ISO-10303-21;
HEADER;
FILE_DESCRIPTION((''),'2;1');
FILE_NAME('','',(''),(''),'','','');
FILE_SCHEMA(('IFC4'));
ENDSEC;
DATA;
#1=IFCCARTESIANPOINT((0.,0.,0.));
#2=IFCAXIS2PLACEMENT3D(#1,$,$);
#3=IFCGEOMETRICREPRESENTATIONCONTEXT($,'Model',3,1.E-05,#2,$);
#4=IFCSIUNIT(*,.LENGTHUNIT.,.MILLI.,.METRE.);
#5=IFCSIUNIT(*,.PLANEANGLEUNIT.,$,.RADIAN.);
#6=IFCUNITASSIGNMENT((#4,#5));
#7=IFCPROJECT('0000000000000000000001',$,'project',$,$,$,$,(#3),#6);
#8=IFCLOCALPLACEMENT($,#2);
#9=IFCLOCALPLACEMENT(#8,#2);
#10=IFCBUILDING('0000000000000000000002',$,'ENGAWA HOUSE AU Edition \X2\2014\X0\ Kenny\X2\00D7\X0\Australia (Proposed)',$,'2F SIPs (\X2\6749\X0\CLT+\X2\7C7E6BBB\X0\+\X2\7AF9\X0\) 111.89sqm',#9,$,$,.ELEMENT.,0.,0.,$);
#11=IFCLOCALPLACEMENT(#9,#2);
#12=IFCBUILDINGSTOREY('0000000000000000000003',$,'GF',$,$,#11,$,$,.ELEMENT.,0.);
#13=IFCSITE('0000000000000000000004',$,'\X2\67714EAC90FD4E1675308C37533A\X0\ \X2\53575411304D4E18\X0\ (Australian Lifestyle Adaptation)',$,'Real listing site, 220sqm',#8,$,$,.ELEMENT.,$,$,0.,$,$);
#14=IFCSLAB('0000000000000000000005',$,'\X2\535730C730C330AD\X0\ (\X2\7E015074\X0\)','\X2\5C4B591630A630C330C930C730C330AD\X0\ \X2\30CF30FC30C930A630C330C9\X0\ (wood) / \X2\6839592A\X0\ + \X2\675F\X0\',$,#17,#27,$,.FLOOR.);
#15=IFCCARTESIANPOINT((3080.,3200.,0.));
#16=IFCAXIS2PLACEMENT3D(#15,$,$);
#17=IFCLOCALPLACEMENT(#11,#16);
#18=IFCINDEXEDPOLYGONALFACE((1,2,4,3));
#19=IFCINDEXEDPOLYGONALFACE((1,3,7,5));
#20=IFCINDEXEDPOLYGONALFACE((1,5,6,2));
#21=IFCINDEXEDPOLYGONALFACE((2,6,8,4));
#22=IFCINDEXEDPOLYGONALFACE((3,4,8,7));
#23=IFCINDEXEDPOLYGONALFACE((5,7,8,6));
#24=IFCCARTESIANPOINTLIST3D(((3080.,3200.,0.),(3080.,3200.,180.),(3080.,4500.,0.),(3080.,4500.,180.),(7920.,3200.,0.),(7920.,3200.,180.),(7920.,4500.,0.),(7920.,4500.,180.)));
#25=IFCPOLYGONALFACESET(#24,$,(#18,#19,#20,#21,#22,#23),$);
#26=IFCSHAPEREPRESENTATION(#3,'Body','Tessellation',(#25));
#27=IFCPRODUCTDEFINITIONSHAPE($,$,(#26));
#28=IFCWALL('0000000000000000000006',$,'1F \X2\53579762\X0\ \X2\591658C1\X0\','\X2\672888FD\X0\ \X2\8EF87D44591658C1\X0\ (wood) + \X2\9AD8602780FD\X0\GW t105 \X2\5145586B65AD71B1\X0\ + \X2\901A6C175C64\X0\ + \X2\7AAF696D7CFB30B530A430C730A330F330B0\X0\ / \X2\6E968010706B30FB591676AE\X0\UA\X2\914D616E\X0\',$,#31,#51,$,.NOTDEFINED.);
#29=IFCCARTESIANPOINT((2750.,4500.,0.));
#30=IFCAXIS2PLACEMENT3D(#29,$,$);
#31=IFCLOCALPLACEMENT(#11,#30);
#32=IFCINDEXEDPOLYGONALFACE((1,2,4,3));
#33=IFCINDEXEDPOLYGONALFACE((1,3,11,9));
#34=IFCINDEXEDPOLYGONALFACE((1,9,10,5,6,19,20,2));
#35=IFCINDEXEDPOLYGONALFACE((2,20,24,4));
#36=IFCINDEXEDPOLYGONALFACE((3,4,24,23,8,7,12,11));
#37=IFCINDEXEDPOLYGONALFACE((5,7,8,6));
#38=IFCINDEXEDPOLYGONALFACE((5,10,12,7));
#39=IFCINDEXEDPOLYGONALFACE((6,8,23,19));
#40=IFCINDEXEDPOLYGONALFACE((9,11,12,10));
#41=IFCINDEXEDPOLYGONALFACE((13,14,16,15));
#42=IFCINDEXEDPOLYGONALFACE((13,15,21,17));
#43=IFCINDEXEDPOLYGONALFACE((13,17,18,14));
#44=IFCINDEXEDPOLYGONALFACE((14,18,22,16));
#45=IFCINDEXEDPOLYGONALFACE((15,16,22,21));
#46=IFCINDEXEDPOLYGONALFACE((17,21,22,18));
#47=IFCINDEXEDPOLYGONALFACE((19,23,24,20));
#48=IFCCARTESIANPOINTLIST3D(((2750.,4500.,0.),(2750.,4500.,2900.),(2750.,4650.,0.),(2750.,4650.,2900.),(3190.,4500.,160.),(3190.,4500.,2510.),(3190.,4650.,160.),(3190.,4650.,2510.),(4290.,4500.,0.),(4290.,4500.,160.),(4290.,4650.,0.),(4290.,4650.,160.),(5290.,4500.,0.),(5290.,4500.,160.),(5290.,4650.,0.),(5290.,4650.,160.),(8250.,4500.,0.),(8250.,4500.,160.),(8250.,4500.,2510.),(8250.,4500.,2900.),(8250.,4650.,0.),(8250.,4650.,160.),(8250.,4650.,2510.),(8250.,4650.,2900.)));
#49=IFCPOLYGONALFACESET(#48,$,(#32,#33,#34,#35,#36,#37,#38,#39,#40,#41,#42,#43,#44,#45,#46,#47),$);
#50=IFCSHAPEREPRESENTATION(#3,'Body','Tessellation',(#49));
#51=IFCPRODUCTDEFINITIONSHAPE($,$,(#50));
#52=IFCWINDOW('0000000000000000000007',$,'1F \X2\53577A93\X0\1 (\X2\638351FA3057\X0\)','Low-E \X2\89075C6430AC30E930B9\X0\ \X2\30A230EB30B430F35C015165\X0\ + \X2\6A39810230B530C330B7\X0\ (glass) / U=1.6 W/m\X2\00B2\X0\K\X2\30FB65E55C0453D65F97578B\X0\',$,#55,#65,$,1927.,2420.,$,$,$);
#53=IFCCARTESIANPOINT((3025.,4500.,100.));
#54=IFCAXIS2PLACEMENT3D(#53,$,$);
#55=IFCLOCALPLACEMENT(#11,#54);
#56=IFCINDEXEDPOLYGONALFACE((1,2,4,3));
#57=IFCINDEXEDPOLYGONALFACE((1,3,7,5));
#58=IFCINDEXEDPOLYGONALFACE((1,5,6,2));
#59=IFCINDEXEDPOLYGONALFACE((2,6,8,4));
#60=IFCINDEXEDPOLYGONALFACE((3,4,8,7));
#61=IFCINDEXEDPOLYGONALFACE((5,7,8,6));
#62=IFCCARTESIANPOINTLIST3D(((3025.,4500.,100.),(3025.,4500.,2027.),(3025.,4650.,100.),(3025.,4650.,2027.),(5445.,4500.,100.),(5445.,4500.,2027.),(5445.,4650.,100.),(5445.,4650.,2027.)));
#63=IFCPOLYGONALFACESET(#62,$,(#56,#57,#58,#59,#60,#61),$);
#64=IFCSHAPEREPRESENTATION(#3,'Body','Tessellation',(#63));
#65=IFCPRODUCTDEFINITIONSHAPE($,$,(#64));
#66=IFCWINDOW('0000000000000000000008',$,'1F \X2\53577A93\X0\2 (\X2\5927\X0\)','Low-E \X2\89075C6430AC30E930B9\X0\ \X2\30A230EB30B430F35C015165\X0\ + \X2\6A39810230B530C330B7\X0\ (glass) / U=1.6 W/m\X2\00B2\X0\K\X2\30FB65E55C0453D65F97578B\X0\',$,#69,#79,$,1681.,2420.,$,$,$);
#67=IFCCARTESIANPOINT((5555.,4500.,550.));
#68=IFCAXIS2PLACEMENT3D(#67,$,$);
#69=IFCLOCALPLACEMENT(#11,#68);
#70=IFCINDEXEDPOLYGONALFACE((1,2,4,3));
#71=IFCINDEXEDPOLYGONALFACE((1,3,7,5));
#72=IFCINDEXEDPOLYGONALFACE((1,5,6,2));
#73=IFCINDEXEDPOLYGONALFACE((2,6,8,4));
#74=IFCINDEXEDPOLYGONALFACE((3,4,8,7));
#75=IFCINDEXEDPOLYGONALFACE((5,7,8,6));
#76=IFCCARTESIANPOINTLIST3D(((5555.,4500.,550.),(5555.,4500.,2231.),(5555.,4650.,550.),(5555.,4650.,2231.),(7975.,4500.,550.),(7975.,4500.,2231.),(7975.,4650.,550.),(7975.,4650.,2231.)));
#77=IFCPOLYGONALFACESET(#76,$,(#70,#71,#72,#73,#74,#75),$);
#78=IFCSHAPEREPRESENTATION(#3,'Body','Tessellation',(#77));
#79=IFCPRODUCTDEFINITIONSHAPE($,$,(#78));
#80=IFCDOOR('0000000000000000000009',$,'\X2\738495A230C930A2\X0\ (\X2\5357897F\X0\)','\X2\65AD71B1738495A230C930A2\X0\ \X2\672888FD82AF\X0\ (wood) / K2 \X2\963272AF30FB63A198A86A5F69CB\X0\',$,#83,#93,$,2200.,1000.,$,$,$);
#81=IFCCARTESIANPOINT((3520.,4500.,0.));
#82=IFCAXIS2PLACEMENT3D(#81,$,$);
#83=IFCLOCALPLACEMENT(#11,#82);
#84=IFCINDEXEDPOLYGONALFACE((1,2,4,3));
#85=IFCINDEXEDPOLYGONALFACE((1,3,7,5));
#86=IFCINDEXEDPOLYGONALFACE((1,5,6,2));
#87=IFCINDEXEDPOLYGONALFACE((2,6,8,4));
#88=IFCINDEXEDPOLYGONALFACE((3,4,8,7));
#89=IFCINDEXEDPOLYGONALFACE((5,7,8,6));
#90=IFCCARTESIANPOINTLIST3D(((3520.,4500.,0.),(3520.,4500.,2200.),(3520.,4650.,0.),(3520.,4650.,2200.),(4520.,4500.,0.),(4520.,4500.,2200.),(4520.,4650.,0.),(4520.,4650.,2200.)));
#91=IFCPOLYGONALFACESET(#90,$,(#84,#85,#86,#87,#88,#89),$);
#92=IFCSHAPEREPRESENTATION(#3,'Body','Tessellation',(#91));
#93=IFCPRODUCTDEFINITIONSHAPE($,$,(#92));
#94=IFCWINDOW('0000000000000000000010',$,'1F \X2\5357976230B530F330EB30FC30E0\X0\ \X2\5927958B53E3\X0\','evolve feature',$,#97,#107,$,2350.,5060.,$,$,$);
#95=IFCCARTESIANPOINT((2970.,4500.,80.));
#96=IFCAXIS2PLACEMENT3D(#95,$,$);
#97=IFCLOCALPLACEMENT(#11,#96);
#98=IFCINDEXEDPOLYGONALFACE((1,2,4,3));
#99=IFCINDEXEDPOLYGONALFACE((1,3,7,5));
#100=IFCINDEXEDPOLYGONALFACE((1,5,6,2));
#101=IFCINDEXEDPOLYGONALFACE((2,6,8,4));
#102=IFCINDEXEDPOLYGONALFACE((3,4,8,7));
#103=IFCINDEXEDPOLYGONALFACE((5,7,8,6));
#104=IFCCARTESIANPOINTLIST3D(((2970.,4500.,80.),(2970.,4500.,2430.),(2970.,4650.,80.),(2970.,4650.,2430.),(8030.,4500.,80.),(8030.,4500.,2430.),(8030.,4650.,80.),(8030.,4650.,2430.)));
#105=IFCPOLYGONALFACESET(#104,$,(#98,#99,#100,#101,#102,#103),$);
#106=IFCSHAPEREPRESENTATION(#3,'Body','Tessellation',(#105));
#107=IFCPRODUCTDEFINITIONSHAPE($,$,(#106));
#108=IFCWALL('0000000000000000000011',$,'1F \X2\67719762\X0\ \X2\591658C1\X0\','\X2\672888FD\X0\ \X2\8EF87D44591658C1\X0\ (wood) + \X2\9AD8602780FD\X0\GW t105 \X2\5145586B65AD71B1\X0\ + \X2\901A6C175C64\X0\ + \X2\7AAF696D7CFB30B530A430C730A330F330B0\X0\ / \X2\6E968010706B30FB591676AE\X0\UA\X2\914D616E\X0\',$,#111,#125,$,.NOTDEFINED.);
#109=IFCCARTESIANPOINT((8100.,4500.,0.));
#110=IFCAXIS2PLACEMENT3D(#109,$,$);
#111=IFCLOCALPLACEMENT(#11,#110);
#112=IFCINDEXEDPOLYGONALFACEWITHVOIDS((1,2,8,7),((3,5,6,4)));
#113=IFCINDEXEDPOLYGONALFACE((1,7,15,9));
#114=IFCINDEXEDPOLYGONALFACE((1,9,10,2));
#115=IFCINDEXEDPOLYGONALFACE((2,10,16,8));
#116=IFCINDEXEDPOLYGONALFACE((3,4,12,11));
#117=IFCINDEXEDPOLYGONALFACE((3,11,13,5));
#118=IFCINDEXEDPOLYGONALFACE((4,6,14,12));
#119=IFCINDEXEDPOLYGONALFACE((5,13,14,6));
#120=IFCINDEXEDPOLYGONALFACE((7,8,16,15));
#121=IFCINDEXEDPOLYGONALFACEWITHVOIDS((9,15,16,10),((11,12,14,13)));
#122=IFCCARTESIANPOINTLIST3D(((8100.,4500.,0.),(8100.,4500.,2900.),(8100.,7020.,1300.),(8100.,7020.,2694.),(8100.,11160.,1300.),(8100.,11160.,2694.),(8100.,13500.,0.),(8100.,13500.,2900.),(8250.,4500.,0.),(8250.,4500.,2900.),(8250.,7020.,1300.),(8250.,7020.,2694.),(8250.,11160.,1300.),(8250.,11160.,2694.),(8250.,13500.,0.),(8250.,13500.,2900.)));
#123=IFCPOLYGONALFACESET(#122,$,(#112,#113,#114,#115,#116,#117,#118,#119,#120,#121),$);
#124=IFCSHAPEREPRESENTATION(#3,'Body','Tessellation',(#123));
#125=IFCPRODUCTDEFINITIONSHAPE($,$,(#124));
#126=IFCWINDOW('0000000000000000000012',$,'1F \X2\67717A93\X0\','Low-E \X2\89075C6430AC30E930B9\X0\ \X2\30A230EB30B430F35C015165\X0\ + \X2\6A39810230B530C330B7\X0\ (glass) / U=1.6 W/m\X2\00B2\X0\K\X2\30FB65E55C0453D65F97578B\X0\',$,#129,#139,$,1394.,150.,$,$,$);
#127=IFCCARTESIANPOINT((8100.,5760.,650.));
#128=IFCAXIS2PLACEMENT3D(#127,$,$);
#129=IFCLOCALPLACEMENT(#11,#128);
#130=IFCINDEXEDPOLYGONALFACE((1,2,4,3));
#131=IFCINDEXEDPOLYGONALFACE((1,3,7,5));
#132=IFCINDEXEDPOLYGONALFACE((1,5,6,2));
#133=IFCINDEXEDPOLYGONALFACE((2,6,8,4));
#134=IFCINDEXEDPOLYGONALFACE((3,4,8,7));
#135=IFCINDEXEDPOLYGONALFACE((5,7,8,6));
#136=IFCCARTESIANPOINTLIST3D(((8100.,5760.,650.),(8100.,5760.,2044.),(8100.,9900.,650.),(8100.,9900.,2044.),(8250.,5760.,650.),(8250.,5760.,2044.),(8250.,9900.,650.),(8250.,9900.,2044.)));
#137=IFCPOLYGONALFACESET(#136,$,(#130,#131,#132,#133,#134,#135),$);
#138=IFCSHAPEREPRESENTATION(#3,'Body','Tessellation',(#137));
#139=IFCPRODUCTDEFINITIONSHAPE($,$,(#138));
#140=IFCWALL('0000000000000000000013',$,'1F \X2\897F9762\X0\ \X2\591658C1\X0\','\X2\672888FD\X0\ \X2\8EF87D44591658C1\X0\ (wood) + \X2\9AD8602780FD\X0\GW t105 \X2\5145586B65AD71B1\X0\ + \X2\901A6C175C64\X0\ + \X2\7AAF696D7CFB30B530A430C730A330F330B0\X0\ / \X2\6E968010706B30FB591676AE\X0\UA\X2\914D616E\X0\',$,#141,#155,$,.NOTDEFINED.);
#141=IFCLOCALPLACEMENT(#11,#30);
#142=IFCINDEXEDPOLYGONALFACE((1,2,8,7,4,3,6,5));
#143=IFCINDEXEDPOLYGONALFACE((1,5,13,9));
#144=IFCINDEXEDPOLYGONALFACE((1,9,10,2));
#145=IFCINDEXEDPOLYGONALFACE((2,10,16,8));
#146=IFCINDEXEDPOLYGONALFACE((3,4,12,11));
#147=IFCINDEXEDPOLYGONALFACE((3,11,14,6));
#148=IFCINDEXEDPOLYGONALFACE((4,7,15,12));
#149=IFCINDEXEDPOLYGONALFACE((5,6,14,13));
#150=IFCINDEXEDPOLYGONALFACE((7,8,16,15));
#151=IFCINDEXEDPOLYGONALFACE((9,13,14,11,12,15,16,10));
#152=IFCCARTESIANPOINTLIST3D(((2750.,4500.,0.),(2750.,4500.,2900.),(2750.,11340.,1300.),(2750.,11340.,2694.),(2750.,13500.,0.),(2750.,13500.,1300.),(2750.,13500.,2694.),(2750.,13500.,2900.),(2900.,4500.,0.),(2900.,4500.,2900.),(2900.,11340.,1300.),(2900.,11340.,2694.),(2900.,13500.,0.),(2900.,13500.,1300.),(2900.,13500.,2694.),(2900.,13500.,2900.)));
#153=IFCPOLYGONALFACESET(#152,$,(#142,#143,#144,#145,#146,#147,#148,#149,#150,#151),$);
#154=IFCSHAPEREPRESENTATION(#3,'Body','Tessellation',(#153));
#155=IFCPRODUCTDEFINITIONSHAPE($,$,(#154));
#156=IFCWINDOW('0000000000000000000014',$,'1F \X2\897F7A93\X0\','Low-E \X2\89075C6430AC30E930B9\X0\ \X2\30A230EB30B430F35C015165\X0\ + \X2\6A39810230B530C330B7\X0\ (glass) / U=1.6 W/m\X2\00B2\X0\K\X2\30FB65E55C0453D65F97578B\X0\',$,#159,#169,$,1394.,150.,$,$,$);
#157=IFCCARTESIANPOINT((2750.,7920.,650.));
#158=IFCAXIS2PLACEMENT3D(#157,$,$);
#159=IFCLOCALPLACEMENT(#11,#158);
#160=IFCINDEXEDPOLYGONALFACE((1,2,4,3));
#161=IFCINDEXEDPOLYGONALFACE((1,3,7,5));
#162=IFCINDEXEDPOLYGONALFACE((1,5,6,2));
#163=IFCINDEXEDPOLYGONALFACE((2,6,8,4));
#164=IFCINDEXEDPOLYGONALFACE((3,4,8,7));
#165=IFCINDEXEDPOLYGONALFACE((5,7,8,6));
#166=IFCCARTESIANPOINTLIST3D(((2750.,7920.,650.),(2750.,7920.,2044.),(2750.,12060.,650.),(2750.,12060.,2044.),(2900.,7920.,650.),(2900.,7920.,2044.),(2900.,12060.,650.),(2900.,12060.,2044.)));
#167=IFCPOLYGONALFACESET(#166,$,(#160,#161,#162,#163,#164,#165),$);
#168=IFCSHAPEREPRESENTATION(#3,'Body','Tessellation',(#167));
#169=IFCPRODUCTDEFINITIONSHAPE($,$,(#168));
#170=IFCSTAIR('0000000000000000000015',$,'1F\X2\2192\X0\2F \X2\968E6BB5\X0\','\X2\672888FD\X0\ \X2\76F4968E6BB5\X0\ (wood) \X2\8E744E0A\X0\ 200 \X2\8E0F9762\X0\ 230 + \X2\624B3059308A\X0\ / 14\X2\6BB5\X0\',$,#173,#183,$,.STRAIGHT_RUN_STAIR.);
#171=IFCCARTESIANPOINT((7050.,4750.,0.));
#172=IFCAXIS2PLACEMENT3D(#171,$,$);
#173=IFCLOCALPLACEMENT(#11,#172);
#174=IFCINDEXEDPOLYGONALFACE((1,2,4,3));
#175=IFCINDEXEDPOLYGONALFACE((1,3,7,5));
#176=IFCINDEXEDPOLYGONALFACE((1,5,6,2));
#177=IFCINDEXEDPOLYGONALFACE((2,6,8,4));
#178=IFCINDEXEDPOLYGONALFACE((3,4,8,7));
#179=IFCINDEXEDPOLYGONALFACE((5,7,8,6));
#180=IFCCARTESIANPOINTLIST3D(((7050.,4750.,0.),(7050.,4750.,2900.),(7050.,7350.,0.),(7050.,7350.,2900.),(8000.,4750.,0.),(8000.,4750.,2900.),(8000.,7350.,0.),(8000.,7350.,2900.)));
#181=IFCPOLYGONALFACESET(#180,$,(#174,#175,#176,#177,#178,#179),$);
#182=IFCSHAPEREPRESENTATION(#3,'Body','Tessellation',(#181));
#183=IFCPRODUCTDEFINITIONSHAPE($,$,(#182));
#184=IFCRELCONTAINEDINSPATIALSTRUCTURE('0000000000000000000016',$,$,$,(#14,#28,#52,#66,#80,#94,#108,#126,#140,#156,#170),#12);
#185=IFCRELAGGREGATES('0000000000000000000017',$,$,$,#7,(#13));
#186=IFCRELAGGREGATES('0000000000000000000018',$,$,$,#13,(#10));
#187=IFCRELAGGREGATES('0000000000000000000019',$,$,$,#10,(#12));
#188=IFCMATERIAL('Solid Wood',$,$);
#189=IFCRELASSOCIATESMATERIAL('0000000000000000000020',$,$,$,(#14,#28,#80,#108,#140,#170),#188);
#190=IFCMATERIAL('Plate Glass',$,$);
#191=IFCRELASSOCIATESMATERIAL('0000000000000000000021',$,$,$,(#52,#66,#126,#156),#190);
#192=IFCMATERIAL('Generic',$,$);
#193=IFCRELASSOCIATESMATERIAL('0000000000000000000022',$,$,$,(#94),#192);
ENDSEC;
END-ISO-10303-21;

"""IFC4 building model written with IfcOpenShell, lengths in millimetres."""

from ifc_helpers import new_model, si_unit, frame, frame_2d, origin, place, context, project, spatial, rectangle, extrude, material, element, fill, save


model = new_model("IFC4")

# Units and contexts
model_context = context("Model", 3, precision=1e-05, world=origin())
ifc_project = project(units=[si_unit("LENGTHUNIT", "METRE", prefix="MILLI"), si_unit("PLANEANGLEUNIT", "RADIAN")], contexts=[model_context])

# Site, building, storey
site_placement = place(None, origin())
site = spatial("IfcSite", under=ifc_project, at=site_placement, Name="東京都世田谷区 南向き丘 (Australian Lifestyle Adaptation)", ObjectType="Real listing site, 220sqm", CompositionType="ELEMENT", RefElevation=0.0)
building_placement = place(site_placement, origin())
building = spatial("IfcBuilding", under=site, at=building_placement, Name="ENGAWA HOUSE AU Edition — Kenny×Australia (Proposed)", ObjectType="2F SIPs (杉CLT+籾殻+竹) 111.89sqm", CompositionType="ELEMENT", ElevationOfRefHeight=0.0, ElevationOfTerrain=0.0)
storey_placement = place(building_placement, origin())
storey = spatial("IfcBuildingStorey", under=building, at=storey_placement, Name="GF", CompositionType="ELEMENT", Elevation=0.0)

# Slab
ifc_material_1 = material(Name="Solid Wood")
slab_1_placement = place(storey_placement, frame((3080.0, 3200.0, 0.0)))
element("IfcSlab", 1, at=slab_1_placement, inside=storey, material=ifc_material_1, Name="南デッキ (縁側)", Description="屋外ウッドデッキ ハードウッド (wood) / 根太 + 束", PredefinedType="FLOOR", context=model_context, shape_type="SweptSolid", body=[
    extrude(rectangle(XDim=4840.0, YDim=1300.0, at=frame_2d((2420.0, 650.0))), frame((3080.0, 3200.0, 0.0)), (0.0, 0.0, 1.0), 180.0),
])
ifc_material_2 = material(Name="Generic")

# Wall, openings, windows, door
wall_1_placement = place(storey_placement, frame((2750.0, 4500.0, 0.0)))
wall_1 = element("IfcWall", 2, at=wall_1_placement, inside=storey, material=ifc_material_1, Name="1F 南面 外壁", Description="木製 軸組外壁 (wood) + 高性能GW t105 充填断熱 + 通気層 + 窯業系サイディング / 準耐火・外皮UA配慮", PredefinedType="NOTDEFINED", context=model_context, shape_type="SweptSolid", body=[
    extrude(rectangle(XDim=5500.0, YDim=150.0, at=frame_2d((2750.0, 75.0))), frame((2750.0, 4500.0, 0.0)), (0.0, 0.0, 1.0), 2900.0),
])
opening_1_placement = place(storey_placement, frame((3025.0, 4500.0, 100.0)))
opening_1 = element("IfcOpeningElement", 3, at=opening_1_placement, cuts=wall_1, PredefinedType="NOTDEFINED", context=model_context, shape_type="SweptSolid", body=[
    extrude(rectangle(XDim=2420.0, YDim=150.0, at=frame_2d((1210.0, 75.0))), frame((3025.0, 4500.0, 100.0)), (0.0, 0.0, 1.0), 1927.0),
])
opening_2_placement = place(storey_placement, frame((5555.0, 4500.0, 550.0)))
opening_2 = element("IfcOpeningElement", 4, at=opening_2_placement, cuts=wall_1, PredefinedType="NOTDEFINED", context=model_context, shape_type="SweptSolid", body=[
    extrude(rectangle(XDim=2420.0, YDim=150.0, at=frame_2d((1210.0, 75.0))), frame((5555.0, 4500.0, 550.0)), (0.0, 0.0, 1.0), 1681.0),
])
opening_3_placement = place(storey_placement, frame((3520.0, 4500.0, 0.0)))
opening_3 = element("IfcOpeningElement", 5, at=opening_3_placement, cuts=wall_1, PredefinedType="NOTDEFINED", context=model_context, shape_type="SweptSolid", body=[
    extrude(rectangle(XDim=1000.0, YDim=150.0, at=frame_2d((500.0, 75.0))), frame((3520.0, 4500.0, 0.0)), (0.0, 0.0, 1.0), 2200.0),
])
opening_4_placement = place(storey_placement, frame((2970.0, 4500.0, 80.0)))
opening_4 = element("IfcOpeningElement", 6, at=opening_4_placement, cuts=wall_1, PredefinedType="NOTDEFINED", context=model_context, shape_type="SweptSolid", body=[
    extrude(rectangle(XDim=5060.0, YDim=150.0, at=frame_2d((2530.0, 75.0))), frame((2970.0, 4500.0, 80.0)), (0.0, 0.0, 1.0), 2350.0),
])
ifc_material_3 = material(Name="Plate Glass")
window_1_placement = place(storey_placement, frame((3025.0, 4500.0, 100.0)))
window_1 = element("IfcWindow", 7, at=window_1_placement, inside=storey, material=ifc_material_3, Name="1F 南窓1 (掃出し)", Description="Low-E 複層ガラス アルゴン封入 + 樹脂サッシ (glass) / U=1.6 W/m²K・日射取得型", OverallHeight=1927.0, OverallWidth=2420.0, context=model_context, shape_type="SweptSolid", body=[
    extrude(rectangle(XDim=2420.0, YDim=150.0, at=frame_2d((1210.0, 75.0))), frame((3025.0, 4500.0, 100.0)), (0.0, 0.0, 1.0), 1927.0),
])
fill(opening_1, window_1)
window_2_placement = place(storey_placement, frame((5555.0, 4500.0, 550.0)))
window_2 = element("IfcWindow", 8, at=window_2_placement, inside=storey, material=ifc_material_3, Name="1F 南窓2 (大)", Description="Low-E 複層ガラス アルゴン封入 + 樹脂サッシ (glass) / U=1.6 W/m²K・日射取得型", OverallHeight=1681.0, OverallWidth=2420.0, context=model_context, shape_type="SweptSolid", body=[
    extrude(rectangle(XDim=2420.0, YDim=150.0, at=frame_2d((1210.0, 75.0))), frame((5555.0, 4500.0, 550.0)), (0.0, 0.0, 1.0), 1681.0),
])
fill(opening_2, window_2)
door_placement = place(storey_placement, frame((3520.0, 4500.0, 0.0)))
door = element("IfcDoor", 9, at=door_placement, inside=storey, material=ifc_material_1, Name="玄関ドア (南西)", Description="断熱玄関ドア 木製芯 (wood) / K2 防犯・採風機構", OverallHeight=2200.0, OverallWidth=1000.0, context=model_context, shape_type="SweptSolid", body=[
    extrude(rectangle(XDim=1000.0, YDim=150.0, at=frame_2d((500.0, 75.0))), frame((3520.0, 4500.0, 0.0)), (0.0, 0.0, 1.0), 2200.0),
])
fill(opening_3, door)
window_3_placement = place(storey_placement, frame((2970.0, 4500.0, 80.0)))
window_3 = element("IfcWindow", 10, at=window_3_placement, inside=storey, material=ifc_material_2, Name="1F 南面サンルーム 大開口", Description="evolve feature", OverallHeight=2350.0, OverallWidth=5060.0, context=model_context, shape_type="SweptSolid", body=[
    extrude(rectangle(XDim=5060.0, YDim=150.0, at=frame_2d((2530.0, 75.0))), frame((2970.0, 4500.0, 80.0)), (0.0, 0.0, 1.0), 2350.0),
])
fill(opening_4, window_3)

# Walls, openings, windows
wall_2_placement = place(storey_placement, frame((8100.0, 4500.0, 0.0)))
wall_2 = element("IfcWall", 11, at=wall_2_placement, inside=storey, material=ifc_material_1, Name="1F 東面 外壁", Description="木製 軸組外壁 (wood) + 高性能GW t105 充填断熱 + 通気層 + 窯業系サイディング / 準耐火・外皮UA配慮", PredefinedType="NOTDEFINED", context=model_context, shape_type="SweptSolid", body=[
    extrude(rectangle(XDim=150.0, YDim=9000.0, at=frame_2d((75.0, 4500.0))), frame((8100.0, 4500.0, 0.0)), (0.0, 0.0, 1.0), 2900.0),
])
opening_5_placement = place(storey_placement, frame((8100.0, 5760.0, 650.0)))
opening_5 = element("IfcOpeningElement", 12, at=opening_5_placement, cuts=wall_2, PredefinedType="NOTDEFINED", context=model_context, shape_type="SweptSolid", body=[
    extrude(rectangle(XDim=150.0, YDim=4140.0, at=frame_2d((75.0, 2070.0))), frame((8100.0, 5760.0, 650.0)), (0.0, 0.0, 1.0), 1394.0),
])
window_4_placement = place(storey_placement, frame((8100.0, 5760.0, 650.0)))
window_4 = element("IfcWindow", 13, at=window_4_placement, inside=storey, material=ifc_material_3, Name="1F 東窓", Description="Low-E 複層ガラス アルゴン封入 + 樹脂サッシ (glass) / U=1.6 W/m²K・日射取得型", OverallHeight=1394.0, OverallWidth=150.0, context=model_context, shape_type="SweptSolid", body=[
    extrude(rectangle(XDim=150.0, YDim=4140.0, at=frame_2d((75.0, 2070.0))), frame((8100.0, 5760.0, 650.0)), (0.0, 0.0, 1.0), 1394.0),
])
fill(opening_5, window_4)
wall_3_placement = place(storey_placement, frame((2750.0, 4500.0, 0.0)))
wall_3 = element("IfcWall", 14, at=wall_3_placement, inside=storey, material=ifc_material_1, Name="1F 西面 外壁", Description="木製 軸組外壁 (wood) + 高性能GW t105 充填断熱 + 通気層 + 窯業系サイディング / 準耐火・外皮UA配慮", PredefinedType="NOTDEFINED", context=model_context, shape_type="SweptSolid", body=[
    extrude(rectangle(XDim=150.0, YDim=9000.0, at=frame_2d((75.0, 4500.0))), frame((2750.0, 4500.0, 0.0)), (0.0, 0.0, 1.0), 2900.0),
])
opening_6_placement = place(storey_placement, frame((2750.0, 7920.0, 650.0)))
opening_6 = element("IfcOpeningElement", 15, at=opening_6_placement, cuts=wall_3, PredefinedType="NOTDEFINED", context=model_context, shape_type="SweptSolid", body=[
    extrude(rectangle(XDim=150.0, YDim=4140.0, at=frame_2d((75.0, 2070.0))), frame((2750.0, 7920.0, 650.0)), (0.0, 0.0, 1.0), 1394.0),
])
window_5_placement = place(storey_placement, frame((2750.0, 7920.0, 650.0)))
window_5 = element("IfcWindow", 16, at=window_5_placement, inside=storey, material=ifc_material_3, Name="1F 西窓", Description="Low-E 複層ガラス アルゴン封入 + 樹脂サッシ (glass) / U=1.6 W/m²K・日射取得型", OverallHeight=1394.0, OverallWidth=150.0, context=model_context, shape_type="SweptSolid", body=[
    extrude(rectangle(XDim=150.0, YDim=4140.0, at=frame_2d((75.0, 2070.0))), frame((2750.0, 7920.0, 650.0)), (0.0, 0.0, 1.0), 1394.0),
])
fill(opening_6, window_5)

# Stair
stair_placement = place(storey_placement, frame((7050.0, 4750.0, 0.0)))
element("IfcStair", 17, at=stair_placement, inside=storey, material=ifc_material_1, Name="1F→2F 階段", Description="木製 直階段 (wood) 蹴上 200 踏面 230 + 手すり / 14段", PredefinedType="STRAIGHT_RUN_STAIR", context=model_context, shape_type="SweptSolid", body=[
    extrude(rectangle(XDim=950.0, YDim=2600.0, at=frame_2d((475.0, 1300.0))), frame((7050.0, 4750.0, 0.0)), (0.0, 0.0, 1.0), 2900.0),
])

save(model, "model.ifc")
